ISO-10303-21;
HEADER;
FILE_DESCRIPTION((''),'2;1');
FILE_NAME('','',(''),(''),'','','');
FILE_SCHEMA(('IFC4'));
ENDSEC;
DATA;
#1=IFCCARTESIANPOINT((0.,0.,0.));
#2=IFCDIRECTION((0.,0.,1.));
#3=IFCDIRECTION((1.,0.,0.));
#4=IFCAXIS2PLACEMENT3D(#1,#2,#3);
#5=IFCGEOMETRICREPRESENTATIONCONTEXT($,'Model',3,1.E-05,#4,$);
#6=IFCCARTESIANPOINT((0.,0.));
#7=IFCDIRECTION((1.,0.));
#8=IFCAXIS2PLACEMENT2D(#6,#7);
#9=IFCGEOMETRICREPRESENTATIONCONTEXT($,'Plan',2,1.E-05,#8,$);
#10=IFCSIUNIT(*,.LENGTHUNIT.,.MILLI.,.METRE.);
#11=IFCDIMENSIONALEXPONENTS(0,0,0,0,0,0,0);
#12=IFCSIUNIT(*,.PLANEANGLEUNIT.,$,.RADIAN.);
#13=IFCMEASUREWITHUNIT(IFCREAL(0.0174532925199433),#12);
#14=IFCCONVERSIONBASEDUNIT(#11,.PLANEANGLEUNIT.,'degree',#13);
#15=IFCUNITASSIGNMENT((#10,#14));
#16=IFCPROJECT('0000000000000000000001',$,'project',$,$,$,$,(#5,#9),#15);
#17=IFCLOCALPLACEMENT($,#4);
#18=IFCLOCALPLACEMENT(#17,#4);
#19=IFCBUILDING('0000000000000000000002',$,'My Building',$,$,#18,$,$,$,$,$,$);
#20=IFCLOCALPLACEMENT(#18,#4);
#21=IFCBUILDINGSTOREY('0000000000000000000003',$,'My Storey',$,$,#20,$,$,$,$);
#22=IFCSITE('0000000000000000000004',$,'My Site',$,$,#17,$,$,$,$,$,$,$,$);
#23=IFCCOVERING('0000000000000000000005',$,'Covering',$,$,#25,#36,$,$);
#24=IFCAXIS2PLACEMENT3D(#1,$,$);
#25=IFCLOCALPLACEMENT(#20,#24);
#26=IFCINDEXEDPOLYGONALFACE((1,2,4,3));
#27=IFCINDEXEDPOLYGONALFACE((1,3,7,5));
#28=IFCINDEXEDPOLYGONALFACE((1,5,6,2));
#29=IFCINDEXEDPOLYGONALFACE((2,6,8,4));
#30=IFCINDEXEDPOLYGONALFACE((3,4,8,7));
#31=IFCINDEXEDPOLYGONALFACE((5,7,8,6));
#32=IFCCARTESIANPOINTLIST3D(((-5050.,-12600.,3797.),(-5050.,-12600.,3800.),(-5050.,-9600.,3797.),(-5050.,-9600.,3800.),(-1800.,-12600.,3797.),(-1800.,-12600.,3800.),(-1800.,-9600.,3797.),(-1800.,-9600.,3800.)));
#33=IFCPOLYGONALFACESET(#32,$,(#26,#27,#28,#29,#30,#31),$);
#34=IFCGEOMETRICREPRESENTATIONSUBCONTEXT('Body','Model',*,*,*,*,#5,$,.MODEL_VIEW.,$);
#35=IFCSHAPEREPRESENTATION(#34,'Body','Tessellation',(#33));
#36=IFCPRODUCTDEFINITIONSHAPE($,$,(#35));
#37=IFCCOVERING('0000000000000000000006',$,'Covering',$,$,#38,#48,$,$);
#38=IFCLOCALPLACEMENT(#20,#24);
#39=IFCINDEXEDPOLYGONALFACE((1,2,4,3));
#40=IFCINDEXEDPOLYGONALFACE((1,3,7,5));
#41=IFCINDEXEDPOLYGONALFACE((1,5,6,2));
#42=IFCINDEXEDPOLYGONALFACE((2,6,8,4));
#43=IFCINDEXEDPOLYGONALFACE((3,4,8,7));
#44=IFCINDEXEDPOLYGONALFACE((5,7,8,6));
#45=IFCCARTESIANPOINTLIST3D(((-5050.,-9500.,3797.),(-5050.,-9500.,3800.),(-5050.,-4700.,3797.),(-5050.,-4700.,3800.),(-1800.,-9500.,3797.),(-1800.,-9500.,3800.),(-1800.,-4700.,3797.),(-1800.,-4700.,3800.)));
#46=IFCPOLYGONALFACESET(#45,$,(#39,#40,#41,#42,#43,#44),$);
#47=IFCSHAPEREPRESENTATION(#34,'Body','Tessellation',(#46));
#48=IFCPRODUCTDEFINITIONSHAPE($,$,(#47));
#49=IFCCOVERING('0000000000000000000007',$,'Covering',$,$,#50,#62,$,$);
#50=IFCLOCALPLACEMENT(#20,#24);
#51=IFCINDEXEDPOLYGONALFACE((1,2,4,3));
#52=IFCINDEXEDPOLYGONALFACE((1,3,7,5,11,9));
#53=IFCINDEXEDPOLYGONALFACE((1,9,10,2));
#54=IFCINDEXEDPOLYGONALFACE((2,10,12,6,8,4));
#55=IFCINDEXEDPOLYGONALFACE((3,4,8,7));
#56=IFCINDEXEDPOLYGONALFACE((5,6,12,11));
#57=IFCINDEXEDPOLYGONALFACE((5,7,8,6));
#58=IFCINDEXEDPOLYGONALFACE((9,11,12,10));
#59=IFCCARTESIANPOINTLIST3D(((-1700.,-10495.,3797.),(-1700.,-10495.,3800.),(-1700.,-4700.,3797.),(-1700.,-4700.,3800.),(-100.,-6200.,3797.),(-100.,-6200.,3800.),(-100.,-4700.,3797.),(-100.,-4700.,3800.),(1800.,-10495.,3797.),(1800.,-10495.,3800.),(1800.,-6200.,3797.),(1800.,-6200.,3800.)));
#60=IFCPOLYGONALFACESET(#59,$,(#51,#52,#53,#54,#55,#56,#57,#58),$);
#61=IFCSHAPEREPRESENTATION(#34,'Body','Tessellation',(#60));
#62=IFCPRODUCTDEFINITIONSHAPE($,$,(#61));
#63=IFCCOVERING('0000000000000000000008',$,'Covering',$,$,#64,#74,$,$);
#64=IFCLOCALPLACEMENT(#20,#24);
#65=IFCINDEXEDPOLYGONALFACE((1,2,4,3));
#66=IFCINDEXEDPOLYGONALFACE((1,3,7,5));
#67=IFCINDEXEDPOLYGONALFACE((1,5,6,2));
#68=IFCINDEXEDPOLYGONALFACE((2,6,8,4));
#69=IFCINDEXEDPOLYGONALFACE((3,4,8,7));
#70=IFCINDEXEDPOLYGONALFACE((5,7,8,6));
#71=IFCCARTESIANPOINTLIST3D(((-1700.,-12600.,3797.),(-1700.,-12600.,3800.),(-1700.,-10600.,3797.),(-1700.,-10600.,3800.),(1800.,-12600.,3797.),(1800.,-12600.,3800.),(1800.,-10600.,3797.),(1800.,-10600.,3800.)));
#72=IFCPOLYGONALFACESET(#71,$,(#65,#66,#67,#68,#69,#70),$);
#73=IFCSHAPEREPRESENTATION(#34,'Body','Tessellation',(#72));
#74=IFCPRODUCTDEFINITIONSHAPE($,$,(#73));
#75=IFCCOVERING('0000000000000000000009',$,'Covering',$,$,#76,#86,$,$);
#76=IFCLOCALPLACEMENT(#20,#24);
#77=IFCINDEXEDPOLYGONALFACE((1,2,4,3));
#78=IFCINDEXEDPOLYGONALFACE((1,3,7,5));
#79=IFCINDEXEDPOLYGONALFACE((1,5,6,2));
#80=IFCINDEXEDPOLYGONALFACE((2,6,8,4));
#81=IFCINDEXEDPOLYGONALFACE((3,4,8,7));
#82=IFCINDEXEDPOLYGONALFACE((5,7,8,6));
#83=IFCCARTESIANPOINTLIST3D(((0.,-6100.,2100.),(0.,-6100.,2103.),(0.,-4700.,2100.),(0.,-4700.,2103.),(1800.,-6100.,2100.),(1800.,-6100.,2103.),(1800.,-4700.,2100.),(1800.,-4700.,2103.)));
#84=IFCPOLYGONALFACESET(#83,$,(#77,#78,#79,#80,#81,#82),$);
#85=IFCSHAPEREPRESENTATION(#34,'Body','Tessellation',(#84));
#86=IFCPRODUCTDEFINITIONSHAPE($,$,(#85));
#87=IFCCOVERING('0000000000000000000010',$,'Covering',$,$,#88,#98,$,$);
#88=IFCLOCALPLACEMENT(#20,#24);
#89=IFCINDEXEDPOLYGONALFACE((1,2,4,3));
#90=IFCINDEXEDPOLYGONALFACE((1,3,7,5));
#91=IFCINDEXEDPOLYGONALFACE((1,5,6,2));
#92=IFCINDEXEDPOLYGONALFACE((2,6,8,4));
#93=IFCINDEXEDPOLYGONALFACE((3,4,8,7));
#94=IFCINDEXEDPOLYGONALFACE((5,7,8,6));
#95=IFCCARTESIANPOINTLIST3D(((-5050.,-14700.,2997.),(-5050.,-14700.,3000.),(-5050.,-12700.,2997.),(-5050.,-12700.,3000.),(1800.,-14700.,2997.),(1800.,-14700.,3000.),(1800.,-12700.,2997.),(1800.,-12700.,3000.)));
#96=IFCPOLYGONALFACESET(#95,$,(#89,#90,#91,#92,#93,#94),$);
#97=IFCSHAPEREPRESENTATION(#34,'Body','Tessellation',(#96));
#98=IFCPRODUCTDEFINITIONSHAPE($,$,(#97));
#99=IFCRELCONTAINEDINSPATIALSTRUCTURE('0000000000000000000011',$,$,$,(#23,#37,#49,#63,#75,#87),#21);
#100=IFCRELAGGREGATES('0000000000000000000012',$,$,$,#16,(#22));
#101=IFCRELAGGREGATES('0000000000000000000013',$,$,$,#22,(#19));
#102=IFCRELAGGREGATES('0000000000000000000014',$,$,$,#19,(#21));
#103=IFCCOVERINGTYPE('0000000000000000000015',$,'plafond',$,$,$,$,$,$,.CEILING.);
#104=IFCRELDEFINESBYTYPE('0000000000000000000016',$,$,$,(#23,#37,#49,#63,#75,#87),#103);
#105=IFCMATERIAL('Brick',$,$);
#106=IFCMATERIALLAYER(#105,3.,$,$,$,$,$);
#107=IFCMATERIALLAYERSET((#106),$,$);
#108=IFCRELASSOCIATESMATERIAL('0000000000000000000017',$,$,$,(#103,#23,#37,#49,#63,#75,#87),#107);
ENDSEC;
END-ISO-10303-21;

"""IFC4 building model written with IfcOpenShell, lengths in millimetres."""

from ifc_helpers import new_model, entity, si_unit, converted_unit, frame, origin_with_axes, origin_2d_with_axis, place, context, subcontext, project, spatial, line, indexed_curve, outline, extrude, material, layer, layer_set, layer_usage, type_object, element, save


model = new_model("IFC4")

# Units and contexts
model_context = context("Model", 3, precision=1e-05, world=origin_with_axes())
plan_context = context("Plan", 2, precision=1e-05, world=origin_2d_with_axis())
body_context_1 = subcontext(model_context, "Body", "Model", "MODEL_VIEW")
ifc_project = project(units=[si_unit("LENGTHUNIT", "METRE", prefix="MILLI"), converted_unit("PLANEANGLEUNIT", "degree", entity("IfcReal", 0.0174532925199433), si_unit("PLANEANGLEUNIT", "RADIAN"), dimensions=[0, 0, 0, 0, 0, 0, 0])], contexts=[model_context, plan_context])

# Site, building, storey
site_placement = place(None, origin_with_axes())
site = spatial("IfcSite", under=ifc_project, at=site_placement, Name="My Site")
building_placement = place(site_placement, origin_with_axes())
building = spatial("IfcBuilding", under=site, at=building_placement, Name="My Building")
storey_placement = place(building_placement, origin_with_axes())
storey = spatial("IfcBuildingStorey", under=building, at=storey_placement, Name="My Storey")

# Shared definitions
ifc_material = material(Name="Brick")

# Coverings
ifc_layer_1 = layer(ifc_material, 3.0)
ifc_layer_set_1 = layer_set([ifc_layer_1])
ifc_layer_usage_1 = layer_usage(ifc_layer_set_1, "AXIS3", "POSITIVE", 0.0)
covering_type = type_object("IfcCoveringType", Name="plafond", PredefinedType="CEILING", material=ifc_layer_set_1)
covering_1_placement = place(storey_placement, frame((-5050.0, -12600.0, 3797.0), z_axis=(0.0, 0.0, 1.0), x_axis=(1.0, 0.0, 0.0)))
element("IfcCovering", 1, at=covering_1_placement, inside=storey, type_object=covering_type, material=ifc_layer_usage_1, Name="Covering", context=body_context_1, shape_type="SweptSolid", body=[
    extrude(outline(indexed_curve([(0.0, 0.0), (3250.0, 0.0), (3250.0, 3000.0), (0.0, 3000.0)], segments=[line(4, 1), line(1, 2), line(2, 3), line(3, 4)], self_intersect=False)), None, (0.0, 0.0, 1.0), 3.0),
])
ifc_layer_usage_2 = layer_usage(ifc_layer_set_1, "AXIS3", "POSITIVE", 0.0)
covering_2_placement = place(storey_placement, frame((-5050.0, -9500.0, 3797.0), z_axis=(0.0, 0.0, 1.0), x_axis=(1.0, 0.0, 0.0)))
element("IfcCovering", 2, at=covering_2_placement, inside=storey, type_object=covering_type, material=ifc_layer_usage_2, Name="Covering", context=body_context_1, shape_type="SweptSolid", body=[
    extrude(outline(indexed_curve([(0.0, 4800.0), (0.0, 0.0), (3250.0, 0.0), (3250.0, 4800.0)], segments=[line(3, 2), line(2, 1), line(1, 4), line(4, 3)], self_intersect=False)), None, (0.0, 0.0, 1.0), 3.0),
])
ifc_layer_usage_3 = layer_usage(ifc_layer_set_1, "AXIS3", "POSITIVE", 0.0)
covering_3_placement = place(storey_placement, frame((-1700.0, -10495.0, 3797.0), z_axis=(0.0, 0.0, 1.0), x_axis=(1.0, 0.0, 0.0)))
element("IfcCovering", 3, at=covering_3_placement, inside=storey, type_object=covering_type, material=ifc_layer_usage_3, Name="Covering", context=body_context_1, shape_type="SweptSolid", body=[
    extrude(outline(indexed_curve([(0.0, 5795.0), (0.0, 0.0), (3500.0, 0.0), (3500.0, 4295.0), (1600.0, 4295.0), (1600.0, 5795.0)], segments=[line(6, 5), line(5, 4), line(4, 3), line(3, 2), line(2, 1), line(1, 6)], self_intersect=False)), None, (0.0, 0.0, 1.0), 3.0),
])
ifc_layer_usage_4 = layer_usage(ifc_layer_set_1, "AXIS3", "POSITIVE", 0.0)
covering_4_placement = place(storey_placement, frame((-1700.0, -12600.0, 3797.0), z_axis=(0.0, 0.0, 1.0), x_axis=(1.0, 0.0, 0.0)))
element("IfcCovering", 4, at=covering_4_placement, inside=storey, type_object=covering_type, material=ifc_layer_usage_4, Name="Covering", context=body_context_1, shape_type="SweptSolid", body=[
    extrude(outline(indexed_curve([(0.0, 0.0), (3500.0, 0.0), (3500.0, 2000.0), (0.0, 2000.0)], segments=[line(4, 1), line(1, 2), line(2, 3), line(3, 4)], self_intersect=False)), None, (0.0, 0.0, 1.0), 3.0),
])
ifc_layer_usage_5 = layer_usage(ifc_layer_set_1, "AXIS3", "POSITIVE", 0.0)
covering_5_placement = place(storey_placement, frame((0.0, -6100.0, 2100.0), z_axis=(0.0, 0.0, 1.0), x_axis=(1.0, 0.0, 0.0)))
element("IfcCovering", 5, at=covering_5_placement, inside=storey, type_object=covering_type, material=ifc_layer_usage_5, Name="Covering", context=body_context_1, shape_type="SweptSolid", body=[
    extrude(outline(indexed_curve([(0.0, 0.0), (1800.0, 0.0), (1800.0, 1400.0), (0.0, 1400.0)], segments=[line(4, 1), line(1, 2), line(2, 3), line(3, 4)], self_intersect=False)), None, (0.0, 0.0, 1.0), 3.0),
])
ifc_layer_usage_6 = layer_usage(ifc_layer_set_1, "AXIS3", "POSITIVE", 0.0)
covering_6_placement = place(storey_placement, frame((-5050.0, -14700.0, 2997.0), z_axis=(0.0, 0.0, 1.0), x_axis=(1.0, 0.0, 0.0)))
element("IfcCovering", 6, at=covering_6_placement, inside=storey, type_object=covering_type, material=ifc_layer_usage_6, Name="Covering", context=body_context_1, shape_type="SweptSolid", body=[
    extrude(outline(indexed_curve([(0.0, 0.0), (6850.0, 0.0), (6850.0, 2000.0), (0.0, 2000.0)], segments=[line(3, 2), line(2, 1), line(1, 4), line(4, 3)], self_intersect=False)), None, (0.0, 0.0, 1.0), 3.0),
])

save(model, "model.ifc")
